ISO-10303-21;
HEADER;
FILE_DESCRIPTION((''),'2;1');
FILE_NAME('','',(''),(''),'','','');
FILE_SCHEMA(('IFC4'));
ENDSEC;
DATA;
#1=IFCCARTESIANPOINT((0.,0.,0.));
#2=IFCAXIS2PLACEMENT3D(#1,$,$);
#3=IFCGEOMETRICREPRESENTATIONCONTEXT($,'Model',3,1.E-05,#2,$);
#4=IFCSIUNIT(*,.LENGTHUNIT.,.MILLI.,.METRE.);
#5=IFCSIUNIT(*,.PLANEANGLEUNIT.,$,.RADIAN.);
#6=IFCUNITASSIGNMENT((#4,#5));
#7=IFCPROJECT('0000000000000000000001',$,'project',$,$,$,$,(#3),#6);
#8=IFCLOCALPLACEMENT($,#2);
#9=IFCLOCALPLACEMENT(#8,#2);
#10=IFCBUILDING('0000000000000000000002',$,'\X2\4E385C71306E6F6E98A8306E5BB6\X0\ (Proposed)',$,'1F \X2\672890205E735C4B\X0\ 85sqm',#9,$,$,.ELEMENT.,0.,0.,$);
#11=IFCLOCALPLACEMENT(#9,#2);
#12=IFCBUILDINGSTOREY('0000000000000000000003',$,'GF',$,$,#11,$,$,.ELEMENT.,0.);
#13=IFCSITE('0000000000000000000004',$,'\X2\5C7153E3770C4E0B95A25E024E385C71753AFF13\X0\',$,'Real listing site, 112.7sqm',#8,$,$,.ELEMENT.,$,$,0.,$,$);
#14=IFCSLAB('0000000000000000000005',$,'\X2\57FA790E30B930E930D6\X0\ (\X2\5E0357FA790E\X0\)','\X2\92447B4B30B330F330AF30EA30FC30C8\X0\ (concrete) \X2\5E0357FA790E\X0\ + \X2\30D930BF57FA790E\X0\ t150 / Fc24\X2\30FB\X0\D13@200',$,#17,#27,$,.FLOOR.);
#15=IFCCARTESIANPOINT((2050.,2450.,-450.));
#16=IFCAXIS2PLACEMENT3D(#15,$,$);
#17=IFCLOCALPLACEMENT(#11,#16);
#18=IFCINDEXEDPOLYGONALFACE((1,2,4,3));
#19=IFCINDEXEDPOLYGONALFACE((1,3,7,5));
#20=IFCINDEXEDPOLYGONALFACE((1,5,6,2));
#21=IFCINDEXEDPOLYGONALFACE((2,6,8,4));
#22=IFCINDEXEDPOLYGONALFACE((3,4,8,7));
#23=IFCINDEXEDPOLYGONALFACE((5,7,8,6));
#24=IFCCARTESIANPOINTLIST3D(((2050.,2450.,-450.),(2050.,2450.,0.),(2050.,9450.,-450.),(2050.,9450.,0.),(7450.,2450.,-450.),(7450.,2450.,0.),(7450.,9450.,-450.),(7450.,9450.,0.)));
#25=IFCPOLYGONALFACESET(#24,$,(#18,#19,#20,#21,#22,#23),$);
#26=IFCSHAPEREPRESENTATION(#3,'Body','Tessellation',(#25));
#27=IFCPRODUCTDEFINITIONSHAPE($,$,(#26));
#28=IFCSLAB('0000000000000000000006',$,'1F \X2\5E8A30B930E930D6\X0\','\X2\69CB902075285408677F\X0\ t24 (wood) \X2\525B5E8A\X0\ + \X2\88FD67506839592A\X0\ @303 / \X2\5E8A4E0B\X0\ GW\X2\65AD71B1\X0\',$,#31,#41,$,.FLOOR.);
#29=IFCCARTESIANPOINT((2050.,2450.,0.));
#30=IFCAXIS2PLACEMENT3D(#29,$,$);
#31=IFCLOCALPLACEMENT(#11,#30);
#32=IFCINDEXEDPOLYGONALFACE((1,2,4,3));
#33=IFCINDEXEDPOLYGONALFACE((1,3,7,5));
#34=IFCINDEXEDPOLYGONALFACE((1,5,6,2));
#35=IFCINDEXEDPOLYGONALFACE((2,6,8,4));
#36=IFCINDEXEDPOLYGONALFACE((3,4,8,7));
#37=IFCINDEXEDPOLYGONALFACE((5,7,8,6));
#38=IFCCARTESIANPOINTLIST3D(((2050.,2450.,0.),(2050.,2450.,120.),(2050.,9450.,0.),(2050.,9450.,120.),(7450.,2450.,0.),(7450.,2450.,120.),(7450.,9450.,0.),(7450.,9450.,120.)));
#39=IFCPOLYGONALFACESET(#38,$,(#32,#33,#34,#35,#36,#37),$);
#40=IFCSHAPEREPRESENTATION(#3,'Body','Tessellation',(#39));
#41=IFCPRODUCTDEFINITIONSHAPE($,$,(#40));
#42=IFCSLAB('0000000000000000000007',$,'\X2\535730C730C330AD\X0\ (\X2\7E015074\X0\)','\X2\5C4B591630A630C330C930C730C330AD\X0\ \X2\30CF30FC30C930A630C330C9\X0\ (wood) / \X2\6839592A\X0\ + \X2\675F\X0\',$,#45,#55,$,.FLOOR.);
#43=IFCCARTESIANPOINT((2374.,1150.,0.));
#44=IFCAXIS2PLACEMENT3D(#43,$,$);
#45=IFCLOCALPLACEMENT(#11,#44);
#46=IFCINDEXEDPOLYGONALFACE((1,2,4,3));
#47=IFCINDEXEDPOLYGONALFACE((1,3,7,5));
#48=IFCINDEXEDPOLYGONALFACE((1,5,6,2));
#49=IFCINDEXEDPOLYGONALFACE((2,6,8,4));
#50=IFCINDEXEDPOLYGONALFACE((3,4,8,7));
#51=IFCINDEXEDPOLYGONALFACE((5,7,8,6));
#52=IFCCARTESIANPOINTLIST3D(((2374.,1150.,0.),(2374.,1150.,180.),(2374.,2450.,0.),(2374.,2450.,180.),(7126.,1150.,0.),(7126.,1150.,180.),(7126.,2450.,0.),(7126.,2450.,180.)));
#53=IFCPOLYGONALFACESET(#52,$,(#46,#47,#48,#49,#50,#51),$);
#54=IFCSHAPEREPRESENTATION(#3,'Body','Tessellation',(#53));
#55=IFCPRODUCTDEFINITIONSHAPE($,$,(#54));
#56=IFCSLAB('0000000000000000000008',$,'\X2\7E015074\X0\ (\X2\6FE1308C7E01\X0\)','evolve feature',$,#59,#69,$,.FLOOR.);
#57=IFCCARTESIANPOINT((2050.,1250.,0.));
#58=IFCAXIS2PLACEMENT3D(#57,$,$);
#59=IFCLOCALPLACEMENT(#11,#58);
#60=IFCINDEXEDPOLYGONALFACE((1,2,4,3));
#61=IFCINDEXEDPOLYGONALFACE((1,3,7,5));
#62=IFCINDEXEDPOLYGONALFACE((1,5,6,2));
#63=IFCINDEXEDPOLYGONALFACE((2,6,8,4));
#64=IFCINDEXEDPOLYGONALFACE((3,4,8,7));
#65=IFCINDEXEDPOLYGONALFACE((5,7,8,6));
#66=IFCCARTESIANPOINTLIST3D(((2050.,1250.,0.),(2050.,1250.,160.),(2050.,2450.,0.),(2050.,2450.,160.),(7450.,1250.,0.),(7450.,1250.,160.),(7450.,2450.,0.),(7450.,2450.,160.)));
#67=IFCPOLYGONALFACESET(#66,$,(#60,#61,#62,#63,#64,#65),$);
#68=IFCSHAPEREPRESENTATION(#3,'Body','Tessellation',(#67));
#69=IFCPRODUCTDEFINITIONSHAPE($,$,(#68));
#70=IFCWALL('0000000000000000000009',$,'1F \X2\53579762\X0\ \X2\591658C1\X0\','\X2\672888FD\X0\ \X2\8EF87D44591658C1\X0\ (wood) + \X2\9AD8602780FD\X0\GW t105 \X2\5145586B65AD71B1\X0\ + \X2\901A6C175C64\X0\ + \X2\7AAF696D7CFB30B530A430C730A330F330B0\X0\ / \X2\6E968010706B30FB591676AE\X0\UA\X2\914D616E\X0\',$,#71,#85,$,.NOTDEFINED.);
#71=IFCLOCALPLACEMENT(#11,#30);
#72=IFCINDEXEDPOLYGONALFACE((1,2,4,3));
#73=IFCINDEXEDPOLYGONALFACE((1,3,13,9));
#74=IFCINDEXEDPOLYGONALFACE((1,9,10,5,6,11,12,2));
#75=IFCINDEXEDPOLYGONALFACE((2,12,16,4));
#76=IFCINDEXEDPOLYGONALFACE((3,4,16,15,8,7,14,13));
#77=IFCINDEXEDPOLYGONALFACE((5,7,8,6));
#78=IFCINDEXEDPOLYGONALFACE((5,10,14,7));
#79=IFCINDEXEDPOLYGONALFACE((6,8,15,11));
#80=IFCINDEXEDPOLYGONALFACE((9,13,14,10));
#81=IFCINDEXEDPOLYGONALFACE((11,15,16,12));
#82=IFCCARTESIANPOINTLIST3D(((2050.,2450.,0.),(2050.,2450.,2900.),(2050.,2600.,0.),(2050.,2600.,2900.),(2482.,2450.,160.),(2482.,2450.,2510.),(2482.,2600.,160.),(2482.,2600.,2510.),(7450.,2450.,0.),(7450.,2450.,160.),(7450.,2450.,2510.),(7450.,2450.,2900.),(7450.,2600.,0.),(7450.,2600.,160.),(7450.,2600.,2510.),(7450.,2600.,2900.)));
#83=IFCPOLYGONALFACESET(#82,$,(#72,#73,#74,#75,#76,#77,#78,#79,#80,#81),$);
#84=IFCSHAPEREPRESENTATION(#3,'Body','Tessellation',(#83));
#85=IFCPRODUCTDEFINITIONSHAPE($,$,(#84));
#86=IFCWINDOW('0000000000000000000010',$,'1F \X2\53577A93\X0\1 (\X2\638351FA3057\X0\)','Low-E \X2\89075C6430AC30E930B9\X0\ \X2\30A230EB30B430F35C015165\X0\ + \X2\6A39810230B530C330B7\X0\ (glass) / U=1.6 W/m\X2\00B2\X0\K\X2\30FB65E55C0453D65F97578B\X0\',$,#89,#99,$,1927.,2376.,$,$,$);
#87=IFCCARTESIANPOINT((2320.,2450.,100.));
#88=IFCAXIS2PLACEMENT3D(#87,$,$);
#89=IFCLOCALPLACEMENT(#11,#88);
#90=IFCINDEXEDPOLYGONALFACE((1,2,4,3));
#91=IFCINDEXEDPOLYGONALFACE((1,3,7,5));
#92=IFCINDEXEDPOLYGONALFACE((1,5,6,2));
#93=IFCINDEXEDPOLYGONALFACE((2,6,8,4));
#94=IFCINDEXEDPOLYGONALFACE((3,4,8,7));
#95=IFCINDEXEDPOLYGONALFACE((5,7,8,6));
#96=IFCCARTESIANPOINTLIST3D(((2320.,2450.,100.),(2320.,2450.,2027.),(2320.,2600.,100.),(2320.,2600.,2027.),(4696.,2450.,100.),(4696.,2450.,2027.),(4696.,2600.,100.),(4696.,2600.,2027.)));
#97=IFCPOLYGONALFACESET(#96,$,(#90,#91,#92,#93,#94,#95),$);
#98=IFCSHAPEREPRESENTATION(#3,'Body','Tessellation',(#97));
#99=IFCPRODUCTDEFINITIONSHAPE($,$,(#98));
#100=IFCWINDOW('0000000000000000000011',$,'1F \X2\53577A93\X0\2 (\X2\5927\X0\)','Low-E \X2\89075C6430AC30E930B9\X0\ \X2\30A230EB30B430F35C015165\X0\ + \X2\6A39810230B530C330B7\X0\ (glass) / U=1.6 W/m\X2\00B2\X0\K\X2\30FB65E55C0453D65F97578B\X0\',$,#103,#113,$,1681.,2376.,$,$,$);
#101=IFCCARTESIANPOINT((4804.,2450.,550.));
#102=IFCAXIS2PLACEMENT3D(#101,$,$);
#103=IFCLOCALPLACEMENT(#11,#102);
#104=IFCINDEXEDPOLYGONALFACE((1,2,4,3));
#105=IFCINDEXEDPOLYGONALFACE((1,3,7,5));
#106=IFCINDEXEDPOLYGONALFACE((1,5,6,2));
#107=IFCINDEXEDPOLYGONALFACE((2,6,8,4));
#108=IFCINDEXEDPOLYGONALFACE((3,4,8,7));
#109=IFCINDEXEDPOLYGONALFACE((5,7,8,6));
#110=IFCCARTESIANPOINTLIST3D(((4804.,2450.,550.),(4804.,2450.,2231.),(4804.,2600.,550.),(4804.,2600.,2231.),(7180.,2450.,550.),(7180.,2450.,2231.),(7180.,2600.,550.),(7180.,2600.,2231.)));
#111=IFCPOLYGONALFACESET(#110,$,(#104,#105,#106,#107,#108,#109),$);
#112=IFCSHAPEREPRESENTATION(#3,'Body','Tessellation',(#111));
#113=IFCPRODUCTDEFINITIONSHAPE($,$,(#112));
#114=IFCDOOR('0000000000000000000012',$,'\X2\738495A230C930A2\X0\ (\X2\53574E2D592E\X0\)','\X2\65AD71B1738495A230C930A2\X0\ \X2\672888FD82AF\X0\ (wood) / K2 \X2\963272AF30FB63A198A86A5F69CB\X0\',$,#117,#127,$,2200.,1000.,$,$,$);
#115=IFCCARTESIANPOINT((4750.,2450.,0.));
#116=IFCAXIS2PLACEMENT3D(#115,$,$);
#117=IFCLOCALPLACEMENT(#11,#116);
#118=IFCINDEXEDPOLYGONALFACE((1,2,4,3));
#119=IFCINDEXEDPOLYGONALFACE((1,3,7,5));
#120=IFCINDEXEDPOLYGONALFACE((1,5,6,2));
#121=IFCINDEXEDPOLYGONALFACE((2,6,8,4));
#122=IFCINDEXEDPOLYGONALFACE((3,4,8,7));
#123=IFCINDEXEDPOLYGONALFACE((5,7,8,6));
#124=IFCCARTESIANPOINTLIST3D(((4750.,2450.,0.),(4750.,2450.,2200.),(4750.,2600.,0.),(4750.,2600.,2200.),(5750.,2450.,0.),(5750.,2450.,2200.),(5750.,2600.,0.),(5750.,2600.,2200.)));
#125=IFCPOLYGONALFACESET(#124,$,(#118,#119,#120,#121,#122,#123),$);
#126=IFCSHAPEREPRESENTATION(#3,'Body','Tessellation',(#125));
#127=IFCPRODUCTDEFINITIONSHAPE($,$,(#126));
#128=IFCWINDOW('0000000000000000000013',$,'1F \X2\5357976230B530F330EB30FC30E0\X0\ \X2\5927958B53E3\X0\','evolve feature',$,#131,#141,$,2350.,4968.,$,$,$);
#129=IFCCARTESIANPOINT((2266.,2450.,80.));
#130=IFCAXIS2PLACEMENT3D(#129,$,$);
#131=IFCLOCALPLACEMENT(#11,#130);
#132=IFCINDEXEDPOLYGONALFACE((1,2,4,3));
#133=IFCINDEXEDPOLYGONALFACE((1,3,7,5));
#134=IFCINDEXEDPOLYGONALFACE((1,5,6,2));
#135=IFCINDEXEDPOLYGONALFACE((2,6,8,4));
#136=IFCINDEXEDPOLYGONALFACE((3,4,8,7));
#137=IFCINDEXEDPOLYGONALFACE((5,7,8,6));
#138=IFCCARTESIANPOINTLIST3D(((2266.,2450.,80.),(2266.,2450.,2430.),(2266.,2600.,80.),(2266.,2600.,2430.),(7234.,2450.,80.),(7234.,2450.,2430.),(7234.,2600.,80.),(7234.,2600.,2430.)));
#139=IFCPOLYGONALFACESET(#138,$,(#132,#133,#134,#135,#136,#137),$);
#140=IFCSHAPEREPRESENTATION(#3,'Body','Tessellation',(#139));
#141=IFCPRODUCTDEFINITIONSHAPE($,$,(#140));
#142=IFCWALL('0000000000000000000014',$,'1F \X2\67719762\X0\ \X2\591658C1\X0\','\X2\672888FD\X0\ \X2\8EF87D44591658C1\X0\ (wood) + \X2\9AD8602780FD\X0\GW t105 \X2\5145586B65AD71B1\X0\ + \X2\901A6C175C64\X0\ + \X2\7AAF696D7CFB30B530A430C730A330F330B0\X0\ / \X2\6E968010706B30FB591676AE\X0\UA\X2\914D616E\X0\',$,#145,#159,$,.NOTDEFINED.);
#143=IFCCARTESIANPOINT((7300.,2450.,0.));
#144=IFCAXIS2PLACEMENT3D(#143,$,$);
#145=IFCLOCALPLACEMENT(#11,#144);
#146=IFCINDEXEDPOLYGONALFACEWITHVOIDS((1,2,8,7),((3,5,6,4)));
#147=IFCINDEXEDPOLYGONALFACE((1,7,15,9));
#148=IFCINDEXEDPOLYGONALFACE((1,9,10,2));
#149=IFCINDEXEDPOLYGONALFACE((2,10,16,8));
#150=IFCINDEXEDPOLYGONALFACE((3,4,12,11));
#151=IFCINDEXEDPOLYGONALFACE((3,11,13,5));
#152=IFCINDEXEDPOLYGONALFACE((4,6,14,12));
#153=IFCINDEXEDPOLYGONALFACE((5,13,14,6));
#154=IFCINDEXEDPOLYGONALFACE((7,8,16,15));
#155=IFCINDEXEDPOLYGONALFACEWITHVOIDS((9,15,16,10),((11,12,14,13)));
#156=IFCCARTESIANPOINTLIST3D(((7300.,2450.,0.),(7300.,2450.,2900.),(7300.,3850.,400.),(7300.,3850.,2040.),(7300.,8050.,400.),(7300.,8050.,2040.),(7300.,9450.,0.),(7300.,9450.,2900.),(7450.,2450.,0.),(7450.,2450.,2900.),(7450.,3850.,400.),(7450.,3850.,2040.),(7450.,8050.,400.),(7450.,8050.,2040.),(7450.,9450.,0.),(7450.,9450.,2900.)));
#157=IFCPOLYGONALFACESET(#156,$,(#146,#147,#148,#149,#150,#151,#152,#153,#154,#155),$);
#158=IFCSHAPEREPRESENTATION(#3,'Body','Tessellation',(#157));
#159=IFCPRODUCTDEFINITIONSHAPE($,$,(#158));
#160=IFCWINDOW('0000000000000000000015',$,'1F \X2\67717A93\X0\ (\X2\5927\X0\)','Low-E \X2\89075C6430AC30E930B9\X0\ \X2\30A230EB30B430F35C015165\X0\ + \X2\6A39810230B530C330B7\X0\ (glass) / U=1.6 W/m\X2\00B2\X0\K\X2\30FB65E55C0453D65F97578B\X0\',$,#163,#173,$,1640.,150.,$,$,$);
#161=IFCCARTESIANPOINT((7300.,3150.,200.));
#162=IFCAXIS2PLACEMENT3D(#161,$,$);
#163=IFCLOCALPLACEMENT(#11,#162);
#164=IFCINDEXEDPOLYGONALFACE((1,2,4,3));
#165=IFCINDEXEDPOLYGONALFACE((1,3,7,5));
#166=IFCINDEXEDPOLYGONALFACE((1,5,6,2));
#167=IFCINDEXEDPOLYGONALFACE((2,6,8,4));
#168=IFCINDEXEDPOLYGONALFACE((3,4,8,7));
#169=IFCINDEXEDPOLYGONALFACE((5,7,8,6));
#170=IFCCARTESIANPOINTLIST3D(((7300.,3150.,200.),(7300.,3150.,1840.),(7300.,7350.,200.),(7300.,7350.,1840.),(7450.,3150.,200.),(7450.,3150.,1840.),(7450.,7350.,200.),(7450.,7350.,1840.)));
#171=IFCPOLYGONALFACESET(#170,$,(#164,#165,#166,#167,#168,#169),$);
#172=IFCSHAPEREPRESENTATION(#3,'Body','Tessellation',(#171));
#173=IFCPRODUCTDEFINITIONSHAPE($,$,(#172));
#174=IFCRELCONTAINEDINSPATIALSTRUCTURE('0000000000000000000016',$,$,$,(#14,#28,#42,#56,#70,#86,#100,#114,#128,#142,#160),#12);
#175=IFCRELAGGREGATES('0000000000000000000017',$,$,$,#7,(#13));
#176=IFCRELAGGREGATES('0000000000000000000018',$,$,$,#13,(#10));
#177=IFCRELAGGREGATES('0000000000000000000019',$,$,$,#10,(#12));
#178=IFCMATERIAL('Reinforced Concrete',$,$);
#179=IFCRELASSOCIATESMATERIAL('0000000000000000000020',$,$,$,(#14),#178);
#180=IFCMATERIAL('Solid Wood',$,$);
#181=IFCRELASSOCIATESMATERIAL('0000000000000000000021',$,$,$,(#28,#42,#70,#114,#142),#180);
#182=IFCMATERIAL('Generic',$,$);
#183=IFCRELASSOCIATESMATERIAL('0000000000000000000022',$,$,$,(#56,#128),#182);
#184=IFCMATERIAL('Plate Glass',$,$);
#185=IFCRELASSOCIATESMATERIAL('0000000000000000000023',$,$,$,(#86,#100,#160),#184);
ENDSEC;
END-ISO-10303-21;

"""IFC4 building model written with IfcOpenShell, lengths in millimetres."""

from ifc_helpers import new_model, si_unit, frame, frame_2d, origin, place, context, project, spatial, rectangle, extrude, material, element, fill, save


model = new_model("IFC4")

# Units and contexts
model_context = context("Model", 3, precision=1e-05, world=origin())
ifc_project = project(units=[si_unit("LENGTHUNIT", "METRE", prefix="MILLI"), si_unit("PLANEANGLEUNIT", "RADIAN")], contexts=[model_context])

# Site, building, storey
site_placement = place(None, origin())
site = spatial("IfcSite", under=ifc_project, at=site_placement, Name="山口県下関市丸山町３", ObjectType="Real listing site, 112.7sqm", CompositionType="ELEMENT", RefElevation=0.0)
building_placement = place(site_placement, origin())
building = spatial("IfcBuilding", under=site, at=building_placement, Name="丸山の潮風の家 (Proposed)", ObjectType="1F 木造平屋 85sqm", CompositionType="ELEMENT", ElevationOfRefHeight=0.0, ElevationOfTerrain=0.0)
storey_placement = place(building_placement, origin())
storey = spatial("IfcBuildingStorey", under=building, at=storey_placement, Name="GF", CompositionType="ELEMENT", Elevation=0.0)

# Slabs
ifc_material_1 = material(Name="Reinforced Concrete")
slab_1_placement = place(storey_placement, frame((2050.0, 2450.0, -450.0)))
element("IfcSlab", 1, at=slab_1_placement, inside=storey, material=ifc_material_1, Name="基礎スラブ (布基礎)", Description="鉄筋コンクリート (concrete) 布基礎 + ベタ基礎 t150 / Fc24・D13@200", PredefinedType="FLOOR", context=model_context, shape_type="SweptSolid", body=[
    extrude(rectangle(XDim=5400.0, YDim=7000.0, at=frame_2d((2700.0, 3500.0))), frame((2050.0, 2450.0, -450.0)), (0.0, 0.0, 1.0), 450.0),
])
ifc_material_2 = material(Name="Solid Wood")
slab_2_placement = place(storey_placement, frame((2050.0, 2450.0, 0.0)))
element("IfcSlab", 2, at=slab_2_placement, inside=storey, material=ifc_material_2, Name="1F 床スラブ", Description="構造用合板 t24 (wood) 剛床 + 製材根太 @303 / 床下 GW断熱", PredefinedType="FLOOR", context=model_context, shape_type="SweptSolid", body=[
    extrude(rectangle(XDim=5400.0, YDim=7000.0, at=frame_2d((2700.0, 3500.0))), frame((2050.0, 2450.0, 0.0)), (0.0, 0.0, 1.0), 120.0),
])
slab_3_placement = place(storey_placement, frame((2374.0, 1150.0, 0.0)))
element("IfcSlab", 3, at=slab_3_placement, inside=storey, material=ifc_material_2, Name="南デッキ (縁側)", Description="屋外ウッドデッキ ハードウッド (wood) / 根太 + 束", PredefinedType="FLOOR", context=model_context, shape_type="SweptSolid", body=[
    extrude(rectangle(XDim=4752.0, YDim=1300.0, at=frame_2d((2376.0, 650.0))), frame((2374.0, 1150.0, 0.0)), (0.0, 0.0, 1.0), 180.0),
])
ifc_material_3 = material(Name="Generic")
slab_4_placement = place(storey_placement, frame((2050.0, 1250.0, 0.0)))
element("IfcSlab", 4, at=slab_4_placement, inside=storey, material=ifc_material_3, Name="縁側 (濡れ縁)", Description="evolve feature", PredefinedType="FLOOR", context=model_context, shape_type="SweptSolid", body=[
    extrude(rectangle(XDim=5400.0, YDim=1200.0, at=frame_2d((2700.0, 600.0))), frame((2050.0, 1250.0, 0.0)), (0.0, 0.0, 1.0), 160.0),
])

# Wall, openings, windows, door
wall_1_placement = place(storey_placement, frame((2050.0, 2450.0, 0.0)))
wall_1 = element("IfcWall", 5, at=wall_1_placement, inside=storey, material=ifc_material_2, Name="1F 南面 外壁", Description="木製 軸組外壁 (wood) + 高性能GW t105 充填断熱 + 通気層 + 窯業系サイディング / 準耐火・外皮UA配慮", PredefinedType="NOTDEFINED", context=model_context, shape_type="SweptSolid", body=[
    extrude(rectangle(XDim=5400.0, YDim=150.0, at=frame_2d((2700.0, 75.0))), frame((2050.0, 2450.0, 0.0)), (0.0, 0.0, 1.0), 2900.0),
])
opening_1_placement = place(storey_placement, frame((2320.0, 2450.0, 100.0)))
opening_1 = element("IfcOpeningElement", 6, at=opening_1_placement, cuts=wall_1, PredefinedType="NOTDEFINED", context=model_context, shape_type="SweptSolid", body=[
    extrude(rectangle(XDim=2376.0, YDim=150.0, at=frame_2d((1188.0, 75.0))), frame((2320.0, 2450.0, 100.0)), (0.0, 0.0, 1.0), 1927.0),
])
opening_2_placement = place(storey_placement, frame((4804.0, 2450.0, 550.0)))
opening_2 = element("IfcOpeningElement", 7, at=opening_2_placement, cuts=wall_1, PredefinedType="NOTDEFINED", context=model_context, shape_type="SweptSolid", body=[
    extrude(rectangle(XDim=2376.0, YDim=150.0, at=frame_2d((1188.0, 75.0))), frame((4804.0, 2450.0, 550.0)), (0.0, 0.0, 1.0), 1681.0),
])
opening_3_placement = place(storey_placement, frame((4750.0, 2450.0, 0.0)))
opening_3 = element("IfcOpeningElement", 8, at=opening_3_placement, cuts=wall_1, PredefinedType="NOTDEFINED", context=model_context, shape_type="SweptSolid", body=[
    extrude(rectangle(XDim=1000.0, YDim=150.0, at=frame_2d((500.0, 75.0))), frame((4750.0, 2450.0, 0.0)), (0.0, 0.0, 1.0), 2200.0),
])
opening_4_placement = place(storey_placement, frame((2266.0, 2450.0, 80.0)))
opening_4 = element("IfcOpeningElement", 9, at=opening_4_placement, cuts=wall_1, PredefinedType="NOTDEFINED", context=model_context, shape_type="SweptSolid", body=[
    extrude(rectangle(XDim=4968.0, YDim=150.0, at=frame_2d((2484.0, 75.0))), frame((2266.0, 2450.0, 80.0)), (0.0, 0.0, 1.0), 2350.0),
])
ifc_material_4 = material(Name="Plate Glass")
window_1_placement = place(storey_placement, frame((2320.0, 2450.0, 100.0)))
window_1 = element("IfcWindow", 10, at=window_1_placement, inside=storey, material=ifc_material_4, Name="1F 南窓1 (掃出し)", Description="Low-E 複層ガラス アルゴン封入 + 樹脂サッシ (glass) / U=1.6 W/m²K・日射取得型", OverallHeight=1927.0, OverallWidth=2376.0, context=model_context, shape_type="SweptSolid", body=[
    extrude(rectangle(XDim=2376.0, YDim=150.0, at=frame_2d((1188.0, 75.0))), frame((2320.0, 2450.0, 100.0)), (0.0, 0.0, 1.0), 1927.0),
])
fill(opening_1, window_1)
window_2_placement = place(storey_placement, frame((4804.0, 2450.0, 550.0)))
window_2 = element("IfcWindow", 11, at=window_2_placement, inside=storey, material=ifc_material_4, Name="1F 南窓2 (大)", Description="Low-E 複層ガラス アルゴン封入 + 樹脂サッシ (glass) / U=1.6 W/m²K・日射取得型", OverallHeight=1681.0, OverallWidth=2376.0, context=model_context, shape_type="SweptSolid", body=[
    extrude(rectangle(XDim=2376.0, YDim=150.0, at=frame_2d((1188.0, 75.0))), frame((4804.0, 2450.0, 550.0)), (0.0, 0.0, 1.0), 1681.0),
])
fill(opening_2, window_2)
door_placement = place(storey_placement, frame((4750.0, 2450.0, 0.0)))
door = element("IfcDoor", 12, at=door_placement, inside=storey, material=ifc_material_2, Name="玄関ドア (南中央)", Description="断熱玄関ドア 木製芯 (wood) / K2 防犯・採風機構", OverallHeight=2200.0, OverallWidth=1000.0, context=model_context, shape_type="SweptSolid", body=[
    extrude(rectangle(XDim=1000.0, YDim=150.0, at=frame_2d((500.0, 75.0))), frame((4750.0, 2450.0, 0.0)), (0.0, 0.0, 1.0), 2200.0),
])
fill(opening_3, door)
window_3_placement = place(storey_placement, frame((2266.0, 2450.0, 80.0)))
window_3 = element("IfcWindow", 13, at=window_3_placement, inside=storey, material=ifc_material_3, Name="1F 南面サンルーム 大開口", Description="evolve feature", OverallHeight=2350.0, OverallWidth=4968.0, context=model_context, shape_type="SweptSolid", body=[
    extrude(rectangle(XDim=4968.0, YDim=150.0, at=frame_2d((2484.0, 75.0))), frame((2266.0, 2450.0, 80.0)), (0.0, 0.0, 1.0), 2350.0),
])
fill(opening_4, window_3)

# Wall, opening, window
wall_2_placement = place(storey_placement, frame((7300.0, 2450.0, 0.0)))
wall_2 = element("IfcWall", 14, at=wall_2_placement, inside=storey, material=ifc_material_2, Name="1F 東面 外壁", Description="木製 軸組外壁 (wood) + 高性能GW t105 充填断熱 + 通気層 + 窯業系サイディング / 準耐火・外皮UA配慮", PredefinedType="NOTDEFINED", context=model_context, shape_type="SweptSolid", body=[
    extrude(rectangle(XDim=150.0, YDim=7000.0, at=frame_2d((75.0, 3500.0))), frame((7300.0, 2450.0, 0.0)), (0.0, 0.0, 1.0), 2900.0),
])
opening_5_placement = place(storey_placement, frame((7300.0, 3150.0, 200.0)))
opening_5 = element("IfcOpeningElement", 15, at=opening_5_placement, cuts=wall_2, PredefinedType="NOTDEFINED", context=model_context, shape_type="SweptSolid", body=[
    extrude(rectangle(XDim=150.0, YDim=4200.0, at=frame_2d((75.0, 2100.0))), frame((7300.0, 3150.0, 200.0)), (0.0, 0.0, 1.0), 1640.0),
])
window_4_placement = place(storey_placement, frame((7300.0, 3150.0, 200.0)))
window_4 = element("IfcWindow", 16, at=window_4_placement, inside=storey, material=ifc_material_4, Name="1F 東窓 (大)", Description="Low-E 複層ガラス アルゴン封入 + 樹脂サッシ (glass) / U=1.6 W/m²K・日射取得型", OverallHeight=1640.0, OverallWidth=150.0, context=model_context, shape_type="SweptSolid", body=[
    extrude(rectangle(XDim=150.0, YDim=4200.0, at=frame_2d((75.0, 2100.0))), frame((7300.0, 3150.0, 200.0)), (0.0, 0.0, 1.0), 1640.0),
])
fill(opening_5, window_4)

save(model, "model.ifc")
